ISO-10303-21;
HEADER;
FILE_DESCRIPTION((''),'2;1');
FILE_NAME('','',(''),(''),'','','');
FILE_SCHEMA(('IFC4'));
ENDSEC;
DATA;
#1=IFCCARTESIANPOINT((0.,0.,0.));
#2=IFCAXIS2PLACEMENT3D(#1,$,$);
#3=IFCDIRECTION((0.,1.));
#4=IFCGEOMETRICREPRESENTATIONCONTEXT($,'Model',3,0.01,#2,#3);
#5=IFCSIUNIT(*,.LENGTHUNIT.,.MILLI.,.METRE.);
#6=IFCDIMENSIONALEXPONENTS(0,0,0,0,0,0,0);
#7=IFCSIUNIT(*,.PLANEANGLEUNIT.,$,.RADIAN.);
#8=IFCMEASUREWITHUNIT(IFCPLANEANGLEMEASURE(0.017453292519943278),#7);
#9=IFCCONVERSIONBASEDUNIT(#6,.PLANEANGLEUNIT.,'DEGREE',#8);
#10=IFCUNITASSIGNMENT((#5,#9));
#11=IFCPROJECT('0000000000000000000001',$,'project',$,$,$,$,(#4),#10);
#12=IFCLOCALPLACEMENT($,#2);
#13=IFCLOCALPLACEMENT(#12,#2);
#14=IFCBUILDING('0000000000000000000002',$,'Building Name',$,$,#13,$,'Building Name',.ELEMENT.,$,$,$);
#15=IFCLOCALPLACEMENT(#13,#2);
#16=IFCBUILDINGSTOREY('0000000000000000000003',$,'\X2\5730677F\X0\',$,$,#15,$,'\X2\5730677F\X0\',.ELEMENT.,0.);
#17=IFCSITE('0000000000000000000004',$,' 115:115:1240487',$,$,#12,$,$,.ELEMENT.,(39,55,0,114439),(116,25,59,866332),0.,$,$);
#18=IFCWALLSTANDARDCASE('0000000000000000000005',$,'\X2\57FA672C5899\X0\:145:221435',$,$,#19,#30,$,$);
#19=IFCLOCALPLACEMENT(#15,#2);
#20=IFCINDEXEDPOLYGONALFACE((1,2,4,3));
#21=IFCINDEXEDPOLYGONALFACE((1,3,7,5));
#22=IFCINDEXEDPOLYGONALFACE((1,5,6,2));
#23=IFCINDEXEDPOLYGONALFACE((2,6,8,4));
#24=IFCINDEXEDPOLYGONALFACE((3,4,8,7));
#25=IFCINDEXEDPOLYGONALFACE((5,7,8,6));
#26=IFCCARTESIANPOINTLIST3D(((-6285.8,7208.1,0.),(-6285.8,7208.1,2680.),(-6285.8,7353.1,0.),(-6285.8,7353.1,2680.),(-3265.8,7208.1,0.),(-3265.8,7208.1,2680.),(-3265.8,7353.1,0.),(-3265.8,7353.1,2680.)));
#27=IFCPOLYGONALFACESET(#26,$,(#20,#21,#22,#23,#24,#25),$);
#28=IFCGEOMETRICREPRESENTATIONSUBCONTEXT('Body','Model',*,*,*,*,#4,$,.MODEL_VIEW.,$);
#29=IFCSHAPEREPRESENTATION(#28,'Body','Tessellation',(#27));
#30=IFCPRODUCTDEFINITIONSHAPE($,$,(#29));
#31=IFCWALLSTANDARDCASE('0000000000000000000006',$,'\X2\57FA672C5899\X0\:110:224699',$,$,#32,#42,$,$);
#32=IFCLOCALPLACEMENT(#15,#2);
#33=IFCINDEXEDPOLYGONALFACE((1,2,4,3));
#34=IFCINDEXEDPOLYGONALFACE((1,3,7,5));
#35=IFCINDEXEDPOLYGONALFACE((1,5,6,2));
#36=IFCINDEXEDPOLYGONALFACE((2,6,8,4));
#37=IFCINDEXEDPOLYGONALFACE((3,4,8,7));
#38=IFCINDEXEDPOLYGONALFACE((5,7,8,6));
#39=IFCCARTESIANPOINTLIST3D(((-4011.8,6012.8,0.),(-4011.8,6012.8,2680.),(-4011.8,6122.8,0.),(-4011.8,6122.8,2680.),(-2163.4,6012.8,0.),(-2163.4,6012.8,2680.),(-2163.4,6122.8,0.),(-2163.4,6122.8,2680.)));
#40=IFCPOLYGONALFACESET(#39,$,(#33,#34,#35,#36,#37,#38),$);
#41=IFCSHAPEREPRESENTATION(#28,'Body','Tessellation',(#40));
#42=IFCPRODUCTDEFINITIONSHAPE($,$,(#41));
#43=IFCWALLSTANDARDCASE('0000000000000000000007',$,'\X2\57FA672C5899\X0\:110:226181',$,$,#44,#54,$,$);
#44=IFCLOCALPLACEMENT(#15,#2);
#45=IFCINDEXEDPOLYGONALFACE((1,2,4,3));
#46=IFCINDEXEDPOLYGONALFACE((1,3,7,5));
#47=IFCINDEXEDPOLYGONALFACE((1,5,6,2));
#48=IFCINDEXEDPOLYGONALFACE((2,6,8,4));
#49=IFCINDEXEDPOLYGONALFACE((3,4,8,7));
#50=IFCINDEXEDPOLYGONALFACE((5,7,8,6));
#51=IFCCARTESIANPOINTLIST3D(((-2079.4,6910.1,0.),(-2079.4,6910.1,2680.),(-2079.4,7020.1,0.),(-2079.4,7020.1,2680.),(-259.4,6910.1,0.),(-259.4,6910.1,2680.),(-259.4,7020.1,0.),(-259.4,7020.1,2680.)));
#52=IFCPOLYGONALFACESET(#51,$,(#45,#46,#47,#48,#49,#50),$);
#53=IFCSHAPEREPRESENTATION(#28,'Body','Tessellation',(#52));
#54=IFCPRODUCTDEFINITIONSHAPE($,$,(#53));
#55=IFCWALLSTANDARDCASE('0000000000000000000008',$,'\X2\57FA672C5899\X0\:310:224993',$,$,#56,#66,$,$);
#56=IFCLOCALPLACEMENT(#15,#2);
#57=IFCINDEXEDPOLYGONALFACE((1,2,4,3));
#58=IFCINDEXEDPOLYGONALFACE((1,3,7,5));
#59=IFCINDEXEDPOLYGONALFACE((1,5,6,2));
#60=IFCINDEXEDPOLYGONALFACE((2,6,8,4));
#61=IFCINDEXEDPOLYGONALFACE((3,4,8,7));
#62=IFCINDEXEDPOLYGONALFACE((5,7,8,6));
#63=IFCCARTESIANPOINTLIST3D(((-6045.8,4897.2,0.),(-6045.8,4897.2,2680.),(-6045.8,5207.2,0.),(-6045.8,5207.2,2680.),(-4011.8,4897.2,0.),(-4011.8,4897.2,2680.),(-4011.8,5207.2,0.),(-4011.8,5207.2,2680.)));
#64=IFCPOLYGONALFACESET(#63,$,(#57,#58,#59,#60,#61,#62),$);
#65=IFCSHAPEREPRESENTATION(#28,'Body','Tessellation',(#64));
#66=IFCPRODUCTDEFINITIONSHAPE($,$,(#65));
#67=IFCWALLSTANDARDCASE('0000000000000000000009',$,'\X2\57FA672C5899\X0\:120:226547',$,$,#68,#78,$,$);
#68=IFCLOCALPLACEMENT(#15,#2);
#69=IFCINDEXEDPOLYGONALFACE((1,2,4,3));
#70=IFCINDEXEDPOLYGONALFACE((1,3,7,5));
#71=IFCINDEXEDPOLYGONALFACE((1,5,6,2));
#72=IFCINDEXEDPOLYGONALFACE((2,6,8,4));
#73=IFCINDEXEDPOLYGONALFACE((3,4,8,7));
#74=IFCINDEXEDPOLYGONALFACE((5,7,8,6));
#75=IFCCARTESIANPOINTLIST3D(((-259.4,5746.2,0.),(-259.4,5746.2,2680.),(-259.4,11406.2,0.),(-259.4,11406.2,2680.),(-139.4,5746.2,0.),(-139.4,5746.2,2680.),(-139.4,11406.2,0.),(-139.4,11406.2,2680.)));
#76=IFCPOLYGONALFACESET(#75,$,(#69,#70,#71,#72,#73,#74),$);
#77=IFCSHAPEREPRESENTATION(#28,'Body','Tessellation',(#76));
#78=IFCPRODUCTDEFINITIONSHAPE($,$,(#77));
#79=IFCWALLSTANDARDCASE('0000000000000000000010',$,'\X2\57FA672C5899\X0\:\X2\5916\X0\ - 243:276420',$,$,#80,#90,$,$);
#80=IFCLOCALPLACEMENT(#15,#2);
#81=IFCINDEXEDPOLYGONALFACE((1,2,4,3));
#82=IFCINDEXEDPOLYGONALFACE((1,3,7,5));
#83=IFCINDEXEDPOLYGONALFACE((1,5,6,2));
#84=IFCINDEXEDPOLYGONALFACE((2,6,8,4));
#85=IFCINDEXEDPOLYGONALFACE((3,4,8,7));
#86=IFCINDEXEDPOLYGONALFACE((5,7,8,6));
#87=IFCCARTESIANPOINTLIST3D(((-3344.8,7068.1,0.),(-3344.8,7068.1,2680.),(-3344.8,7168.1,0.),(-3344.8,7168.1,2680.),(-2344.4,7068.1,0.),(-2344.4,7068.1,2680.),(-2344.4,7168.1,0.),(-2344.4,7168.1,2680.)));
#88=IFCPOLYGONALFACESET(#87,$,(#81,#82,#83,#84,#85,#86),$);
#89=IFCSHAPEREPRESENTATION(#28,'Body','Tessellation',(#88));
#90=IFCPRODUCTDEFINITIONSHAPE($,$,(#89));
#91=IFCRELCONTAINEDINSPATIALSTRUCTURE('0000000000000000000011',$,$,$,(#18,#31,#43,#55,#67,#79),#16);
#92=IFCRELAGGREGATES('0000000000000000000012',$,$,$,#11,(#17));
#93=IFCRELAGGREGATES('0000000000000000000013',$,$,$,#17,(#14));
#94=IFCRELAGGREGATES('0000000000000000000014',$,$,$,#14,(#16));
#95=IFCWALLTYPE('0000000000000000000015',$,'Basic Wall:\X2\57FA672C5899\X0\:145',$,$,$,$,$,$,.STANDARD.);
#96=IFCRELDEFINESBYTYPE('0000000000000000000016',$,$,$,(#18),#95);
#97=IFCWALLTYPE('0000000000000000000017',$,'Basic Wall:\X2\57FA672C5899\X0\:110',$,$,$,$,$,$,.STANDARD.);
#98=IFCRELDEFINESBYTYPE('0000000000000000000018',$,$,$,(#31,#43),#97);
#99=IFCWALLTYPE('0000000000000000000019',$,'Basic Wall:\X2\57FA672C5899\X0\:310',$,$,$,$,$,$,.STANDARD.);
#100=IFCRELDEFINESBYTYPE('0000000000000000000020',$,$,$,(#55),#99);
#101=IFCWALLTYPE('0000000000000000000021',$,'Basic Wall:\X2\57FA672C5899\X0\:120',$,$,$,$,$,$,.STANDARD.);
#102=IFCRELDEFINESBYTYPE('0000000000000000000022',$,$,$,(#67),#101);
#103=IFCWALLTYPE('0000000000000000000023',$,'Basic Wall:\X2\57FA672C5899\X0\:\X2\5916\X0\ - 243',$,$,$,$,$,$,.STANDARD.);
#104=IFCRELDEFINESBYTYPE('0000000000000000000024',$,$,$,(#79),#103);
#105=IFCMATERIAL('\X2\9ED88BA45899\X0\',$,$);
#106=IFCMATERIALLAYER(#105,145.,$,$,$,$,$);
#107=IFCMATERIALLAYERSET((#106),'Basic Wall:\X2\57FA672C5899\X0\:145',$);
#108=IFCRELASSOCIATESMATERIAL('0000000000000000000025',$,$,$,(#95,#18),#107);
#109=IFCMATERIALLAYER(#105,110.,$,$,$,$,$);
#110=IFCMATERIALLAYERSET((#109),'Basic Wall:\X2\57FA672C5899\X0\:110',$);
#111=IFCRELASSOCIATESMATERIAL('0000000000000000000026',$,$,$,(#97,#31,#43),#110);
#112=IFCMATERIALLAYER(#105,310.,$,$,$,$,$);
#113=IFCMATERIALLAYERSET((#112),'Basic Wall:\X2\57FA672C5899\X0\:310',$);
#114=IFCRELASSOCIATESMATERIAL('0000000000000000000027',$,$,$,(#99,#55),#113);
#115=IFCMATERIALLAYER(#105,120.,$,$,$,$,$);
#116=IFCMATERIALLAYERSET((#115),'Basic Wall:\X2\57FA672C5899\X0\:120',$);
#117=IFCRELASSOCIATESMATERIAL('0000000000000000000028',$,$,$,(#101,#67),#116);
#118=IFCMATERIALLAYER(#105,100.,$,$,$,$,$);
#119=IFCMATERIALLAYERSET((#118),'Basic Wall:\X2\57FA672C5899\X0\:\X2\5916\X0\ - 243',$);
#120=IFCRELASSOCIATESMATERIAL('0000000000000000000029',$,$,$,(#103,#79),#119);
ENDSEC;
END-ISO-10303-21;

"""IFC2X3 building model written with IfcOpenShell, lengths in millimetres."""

from ifc_helpers import new_model, entity, si_unit, converted_unit, direction, frame, frame_2d, origin, place, context, subcontext, project, spatial, rectangle, extrude, material, layer, layer_set, layer_usage, type_object, element, save


model = new_model("IFC2X3")

# Units and contexts
model_context = context("Model", 3, precision=0.01, world=origin(), true_north=direction((0.0, 1.0)))
body_context = subcontext(model_context, "Body", "Model", "MODEL_VIEW")
ifc_project = project(units=[si_unit("LENGTHUNIT", "METRE", prefix="MILLI"), converted_unit("PLANEANGLEUNIT", "DEGREE", entity("IfcPlaneAngleMeasure", 0.017453292519943278), si_unit("PLANEANGLEUNIT", "RADIAN"), dimensions=[0, 0, 0, 0, 0, 0, 0])], contexts=[model_context])

# Site, building, storey
site_placement = place(None, origin())
site = spatial("IfcSite", under=ifc_project, at=site_placement, Name=" 115:115:1240487", CompositionType="ELEMENT", RefLatitude=(39, 55, 0, 114439), RefLongitude=(116, 25, 59, 866332), RefElevation=0.0)
building_placement = place(site_placement, origin())
building = spatial("IfcBuilding", under=site, at=building_placement, Name="Building Name", LongName="Building Name", CompositionType="ELEMENT")
storey_placement = place(building_placement, origin())
storey = spatial("IfcBuildingStorey", under=building, at=storey_placement, Name="地板", LongName="地板", CompositionType="ELEMENT", Elevation=0.0)

# Shared definitions
ifc_material_1 = material(Name="默认墙")

# Walls
ifc_layer_1 = layer(ifc_material_1, 145.0)
ifc_layer_set_1 = layer_set([ifc_layer_1], Name="Basic Wall:基本墙:145")
ifc_layer_usage_1 = layer_usage(ifc_layer_set_1, "AXIS2", "NEGATIVE", 72.5)
wall_type_1 = type_object("IfcWallType", Name="Basic Wall:基本墙:145", PredefinedType="STANDARD", material=ifc_layer_set_1)
wall_1_placement = place(storey_placement, frame((-3265.8, 7280.6, 0.0), z_axis=(0.0, 0.0, 1.0), x_axis=(-1.0, 0.0, 0.0)))
element("IfcWallStandardCase", 1, at=wall_1_placement, inside=storey, type_object=wall_type_1, material=ifc_layer_usage_1, Name="基本墙:145:221435", context=body_context, shape_type="SweptSolid", body=[
    extrude(rectangle(XDim=3020.0, YDim=145.0, at=frame_2d((1510.0, 0.0), x_axis=(-1.0, 0.0))), origin(), (0.0, 0.0, 1.0), 2680.0),
])
ifc_layer_2 = layer(ifc_material_1, 110.0)
ifc_layer_set_2 = layer_set([ifc_layer_2], Name="Basic Wall:基本墙:110")
ifc_layer_usage_2 = layer_usage(ifc_layer_set_2, "AXIS2", "NEGATIVE", 55.0)
wall_type_2 = type_object("IfcWallType", Name="Basic Wall:基本墙:110", PredefinedType="STANDARD", material=ifc_layer_set_2)
wall_2_placement = place(storey_placement, frame((-2163.4, 6067.8, 0.0), z_axis=(0.0, 0.0, 1.0), x_axis=(-1.0, 0.0, 0.0)))
element("IfcWallStandardCase", 2, at=wall_2_placement, inside=storey, type_object=wall_type_2, material=ifc_layer_usage_2, Name="基本墙:110:224699", context=body_context, shape_type="SweptSolid", body=[
    extrude(rectangle(XDim=1848.4, YDim=110.0, at=frame_2d((924.2, 0.0), x_axis=(-1.0, 0.0))), origin(), (0.0, 0.0, 1.0), 2680.0),
])
ifc_layer_usage_3 = layer_usage(ifc_layer_set_2, "AXIS2", "NEGATIVE", 55.0)
wall_3_placement = place(storey_placement, frame((-2079.4, 6965.1, 0.0)))
element("IfcWallStandardCase", 3, at=wall_3_placement, inside=storey, type_object=wall_type_2, material=ifc_layer_usage_3, Name="基本墙:110:226181", context=body_context, shape_type="SweptSolid", body=[
    extrude(rectangle(XDim=1820.0, YDim=110.0, at=frame_2d((910.0, 0.0), x_axis=(-1.0, 0.0))), origin(), (0.0, 0.0, 1.0), 2680.0),
])
ifc_layer_3 = layer(ifc_material_1, 310.0)
ifc_layer_set_3 = layer_set([ifc_layer_3], Name="Basic Wall:基本墙:310")
ifc_layer_usage_4 = layer_usage(ifc_layer_set_3, "AXIS2", "NEGATIVE", 155.0)
wall_type_3 = type_object("IfcWallType", Name="Basic Wall:基本墙:310", PredefinedType="STANDARD", material=ifc_layer_set_3)
wall_4_placement = place(storey_placement, frame((-6045.8, 5052.2, 0.0)))
element("IfcWallStandardCase", 4, at=wall_4_placement, inside=storey, type_object=wall_type_3, material=ifc_layer_usage_4, Name="基本墙:310:224993", context=body_context, shape_type="SweptSolid", body=[
    extrude(rectangle(XDim=2034.0, YDim=310.0, at=frame_2d((1017.0, 0.0), x_axis=(-1.0, 0.0))), origin(), (0.0, 0.0, 1.0), 2680.0),
])
ifc_layer_4 = layer(ifc_material_1, 120.0)
ifc_layer_set_4 = layer_set([ifc_layer_4], Name="Basic Wall:基本墙:120")
ifc_layer_usage_5 = layer_usage(ifc_layer_set_4, "AXIS2", "NEGATIVE", 60.0)
wall_type_4 = type_object("IfcWallType", Name="Basic Wall:基本墙:120", PredefinedType="STANDARD", material=ifc_layer_set_4)
wall_5_placement = place(storey_placement, frame((-199.4, 5746.2, 0.0), z_axis=(0.0, 0.0, 1.0), x_axis=(0.0, 1.0, 0.0)))
element("IfcWallStandardCase", 5, at=wall_5_placement, inside=storey, type_object=wall_type_4, material=ifc_layer_usage_5, Name="基本墙:120:226547", context=body_context, shape_type="SweptSolid", body=[
    extrude(rectangle(XDim=5660.0, YDim=120.0, at=frame_2d((2830.0, 0.0), x_axis=(-1.0, 0.0))), origin(), (0.0, 0.0, 1.0), 2680.0),
])
ifc_layer_5 = layer(ifc_material_1, 100.0)
ifc_layer_set_5 = layer_set([ifc_layer_5], Name="Basic Wall:基本墙:外 - 243")
ifc_layer_usage_6 = layer_usage(ifc_layer_set_5, "AXIS2", "NEGATIVE", 50.0)
wall_type_5 = type_object("IfcWallType", Name="Basic Wall:基本墙:外 - 243", PredefinedType="STANDARD", material=ifc_layer_set_5)
wall_6_placement = place(storey_placement, frame((-3344.8, 7118.1, 0.0)))
element("IfcWallStandardCase", 6, at=wall_6_placement, inside=storey, type_object=wall_type_5, material=ifc_layer_usage_6, Name="基本墙:外 - 243:276420", context=body_context, shape_type="SweptSolid", body=[
    extrude(rectangle(XDim=1000.3, YDim=100.0, at=frame_2d((500.2, 0.0), x_axis=(-1.0, 0.0))), origin(), (0.0, 0.0, 1.0), 2680.0),
])

save(model, "model.ifc")
